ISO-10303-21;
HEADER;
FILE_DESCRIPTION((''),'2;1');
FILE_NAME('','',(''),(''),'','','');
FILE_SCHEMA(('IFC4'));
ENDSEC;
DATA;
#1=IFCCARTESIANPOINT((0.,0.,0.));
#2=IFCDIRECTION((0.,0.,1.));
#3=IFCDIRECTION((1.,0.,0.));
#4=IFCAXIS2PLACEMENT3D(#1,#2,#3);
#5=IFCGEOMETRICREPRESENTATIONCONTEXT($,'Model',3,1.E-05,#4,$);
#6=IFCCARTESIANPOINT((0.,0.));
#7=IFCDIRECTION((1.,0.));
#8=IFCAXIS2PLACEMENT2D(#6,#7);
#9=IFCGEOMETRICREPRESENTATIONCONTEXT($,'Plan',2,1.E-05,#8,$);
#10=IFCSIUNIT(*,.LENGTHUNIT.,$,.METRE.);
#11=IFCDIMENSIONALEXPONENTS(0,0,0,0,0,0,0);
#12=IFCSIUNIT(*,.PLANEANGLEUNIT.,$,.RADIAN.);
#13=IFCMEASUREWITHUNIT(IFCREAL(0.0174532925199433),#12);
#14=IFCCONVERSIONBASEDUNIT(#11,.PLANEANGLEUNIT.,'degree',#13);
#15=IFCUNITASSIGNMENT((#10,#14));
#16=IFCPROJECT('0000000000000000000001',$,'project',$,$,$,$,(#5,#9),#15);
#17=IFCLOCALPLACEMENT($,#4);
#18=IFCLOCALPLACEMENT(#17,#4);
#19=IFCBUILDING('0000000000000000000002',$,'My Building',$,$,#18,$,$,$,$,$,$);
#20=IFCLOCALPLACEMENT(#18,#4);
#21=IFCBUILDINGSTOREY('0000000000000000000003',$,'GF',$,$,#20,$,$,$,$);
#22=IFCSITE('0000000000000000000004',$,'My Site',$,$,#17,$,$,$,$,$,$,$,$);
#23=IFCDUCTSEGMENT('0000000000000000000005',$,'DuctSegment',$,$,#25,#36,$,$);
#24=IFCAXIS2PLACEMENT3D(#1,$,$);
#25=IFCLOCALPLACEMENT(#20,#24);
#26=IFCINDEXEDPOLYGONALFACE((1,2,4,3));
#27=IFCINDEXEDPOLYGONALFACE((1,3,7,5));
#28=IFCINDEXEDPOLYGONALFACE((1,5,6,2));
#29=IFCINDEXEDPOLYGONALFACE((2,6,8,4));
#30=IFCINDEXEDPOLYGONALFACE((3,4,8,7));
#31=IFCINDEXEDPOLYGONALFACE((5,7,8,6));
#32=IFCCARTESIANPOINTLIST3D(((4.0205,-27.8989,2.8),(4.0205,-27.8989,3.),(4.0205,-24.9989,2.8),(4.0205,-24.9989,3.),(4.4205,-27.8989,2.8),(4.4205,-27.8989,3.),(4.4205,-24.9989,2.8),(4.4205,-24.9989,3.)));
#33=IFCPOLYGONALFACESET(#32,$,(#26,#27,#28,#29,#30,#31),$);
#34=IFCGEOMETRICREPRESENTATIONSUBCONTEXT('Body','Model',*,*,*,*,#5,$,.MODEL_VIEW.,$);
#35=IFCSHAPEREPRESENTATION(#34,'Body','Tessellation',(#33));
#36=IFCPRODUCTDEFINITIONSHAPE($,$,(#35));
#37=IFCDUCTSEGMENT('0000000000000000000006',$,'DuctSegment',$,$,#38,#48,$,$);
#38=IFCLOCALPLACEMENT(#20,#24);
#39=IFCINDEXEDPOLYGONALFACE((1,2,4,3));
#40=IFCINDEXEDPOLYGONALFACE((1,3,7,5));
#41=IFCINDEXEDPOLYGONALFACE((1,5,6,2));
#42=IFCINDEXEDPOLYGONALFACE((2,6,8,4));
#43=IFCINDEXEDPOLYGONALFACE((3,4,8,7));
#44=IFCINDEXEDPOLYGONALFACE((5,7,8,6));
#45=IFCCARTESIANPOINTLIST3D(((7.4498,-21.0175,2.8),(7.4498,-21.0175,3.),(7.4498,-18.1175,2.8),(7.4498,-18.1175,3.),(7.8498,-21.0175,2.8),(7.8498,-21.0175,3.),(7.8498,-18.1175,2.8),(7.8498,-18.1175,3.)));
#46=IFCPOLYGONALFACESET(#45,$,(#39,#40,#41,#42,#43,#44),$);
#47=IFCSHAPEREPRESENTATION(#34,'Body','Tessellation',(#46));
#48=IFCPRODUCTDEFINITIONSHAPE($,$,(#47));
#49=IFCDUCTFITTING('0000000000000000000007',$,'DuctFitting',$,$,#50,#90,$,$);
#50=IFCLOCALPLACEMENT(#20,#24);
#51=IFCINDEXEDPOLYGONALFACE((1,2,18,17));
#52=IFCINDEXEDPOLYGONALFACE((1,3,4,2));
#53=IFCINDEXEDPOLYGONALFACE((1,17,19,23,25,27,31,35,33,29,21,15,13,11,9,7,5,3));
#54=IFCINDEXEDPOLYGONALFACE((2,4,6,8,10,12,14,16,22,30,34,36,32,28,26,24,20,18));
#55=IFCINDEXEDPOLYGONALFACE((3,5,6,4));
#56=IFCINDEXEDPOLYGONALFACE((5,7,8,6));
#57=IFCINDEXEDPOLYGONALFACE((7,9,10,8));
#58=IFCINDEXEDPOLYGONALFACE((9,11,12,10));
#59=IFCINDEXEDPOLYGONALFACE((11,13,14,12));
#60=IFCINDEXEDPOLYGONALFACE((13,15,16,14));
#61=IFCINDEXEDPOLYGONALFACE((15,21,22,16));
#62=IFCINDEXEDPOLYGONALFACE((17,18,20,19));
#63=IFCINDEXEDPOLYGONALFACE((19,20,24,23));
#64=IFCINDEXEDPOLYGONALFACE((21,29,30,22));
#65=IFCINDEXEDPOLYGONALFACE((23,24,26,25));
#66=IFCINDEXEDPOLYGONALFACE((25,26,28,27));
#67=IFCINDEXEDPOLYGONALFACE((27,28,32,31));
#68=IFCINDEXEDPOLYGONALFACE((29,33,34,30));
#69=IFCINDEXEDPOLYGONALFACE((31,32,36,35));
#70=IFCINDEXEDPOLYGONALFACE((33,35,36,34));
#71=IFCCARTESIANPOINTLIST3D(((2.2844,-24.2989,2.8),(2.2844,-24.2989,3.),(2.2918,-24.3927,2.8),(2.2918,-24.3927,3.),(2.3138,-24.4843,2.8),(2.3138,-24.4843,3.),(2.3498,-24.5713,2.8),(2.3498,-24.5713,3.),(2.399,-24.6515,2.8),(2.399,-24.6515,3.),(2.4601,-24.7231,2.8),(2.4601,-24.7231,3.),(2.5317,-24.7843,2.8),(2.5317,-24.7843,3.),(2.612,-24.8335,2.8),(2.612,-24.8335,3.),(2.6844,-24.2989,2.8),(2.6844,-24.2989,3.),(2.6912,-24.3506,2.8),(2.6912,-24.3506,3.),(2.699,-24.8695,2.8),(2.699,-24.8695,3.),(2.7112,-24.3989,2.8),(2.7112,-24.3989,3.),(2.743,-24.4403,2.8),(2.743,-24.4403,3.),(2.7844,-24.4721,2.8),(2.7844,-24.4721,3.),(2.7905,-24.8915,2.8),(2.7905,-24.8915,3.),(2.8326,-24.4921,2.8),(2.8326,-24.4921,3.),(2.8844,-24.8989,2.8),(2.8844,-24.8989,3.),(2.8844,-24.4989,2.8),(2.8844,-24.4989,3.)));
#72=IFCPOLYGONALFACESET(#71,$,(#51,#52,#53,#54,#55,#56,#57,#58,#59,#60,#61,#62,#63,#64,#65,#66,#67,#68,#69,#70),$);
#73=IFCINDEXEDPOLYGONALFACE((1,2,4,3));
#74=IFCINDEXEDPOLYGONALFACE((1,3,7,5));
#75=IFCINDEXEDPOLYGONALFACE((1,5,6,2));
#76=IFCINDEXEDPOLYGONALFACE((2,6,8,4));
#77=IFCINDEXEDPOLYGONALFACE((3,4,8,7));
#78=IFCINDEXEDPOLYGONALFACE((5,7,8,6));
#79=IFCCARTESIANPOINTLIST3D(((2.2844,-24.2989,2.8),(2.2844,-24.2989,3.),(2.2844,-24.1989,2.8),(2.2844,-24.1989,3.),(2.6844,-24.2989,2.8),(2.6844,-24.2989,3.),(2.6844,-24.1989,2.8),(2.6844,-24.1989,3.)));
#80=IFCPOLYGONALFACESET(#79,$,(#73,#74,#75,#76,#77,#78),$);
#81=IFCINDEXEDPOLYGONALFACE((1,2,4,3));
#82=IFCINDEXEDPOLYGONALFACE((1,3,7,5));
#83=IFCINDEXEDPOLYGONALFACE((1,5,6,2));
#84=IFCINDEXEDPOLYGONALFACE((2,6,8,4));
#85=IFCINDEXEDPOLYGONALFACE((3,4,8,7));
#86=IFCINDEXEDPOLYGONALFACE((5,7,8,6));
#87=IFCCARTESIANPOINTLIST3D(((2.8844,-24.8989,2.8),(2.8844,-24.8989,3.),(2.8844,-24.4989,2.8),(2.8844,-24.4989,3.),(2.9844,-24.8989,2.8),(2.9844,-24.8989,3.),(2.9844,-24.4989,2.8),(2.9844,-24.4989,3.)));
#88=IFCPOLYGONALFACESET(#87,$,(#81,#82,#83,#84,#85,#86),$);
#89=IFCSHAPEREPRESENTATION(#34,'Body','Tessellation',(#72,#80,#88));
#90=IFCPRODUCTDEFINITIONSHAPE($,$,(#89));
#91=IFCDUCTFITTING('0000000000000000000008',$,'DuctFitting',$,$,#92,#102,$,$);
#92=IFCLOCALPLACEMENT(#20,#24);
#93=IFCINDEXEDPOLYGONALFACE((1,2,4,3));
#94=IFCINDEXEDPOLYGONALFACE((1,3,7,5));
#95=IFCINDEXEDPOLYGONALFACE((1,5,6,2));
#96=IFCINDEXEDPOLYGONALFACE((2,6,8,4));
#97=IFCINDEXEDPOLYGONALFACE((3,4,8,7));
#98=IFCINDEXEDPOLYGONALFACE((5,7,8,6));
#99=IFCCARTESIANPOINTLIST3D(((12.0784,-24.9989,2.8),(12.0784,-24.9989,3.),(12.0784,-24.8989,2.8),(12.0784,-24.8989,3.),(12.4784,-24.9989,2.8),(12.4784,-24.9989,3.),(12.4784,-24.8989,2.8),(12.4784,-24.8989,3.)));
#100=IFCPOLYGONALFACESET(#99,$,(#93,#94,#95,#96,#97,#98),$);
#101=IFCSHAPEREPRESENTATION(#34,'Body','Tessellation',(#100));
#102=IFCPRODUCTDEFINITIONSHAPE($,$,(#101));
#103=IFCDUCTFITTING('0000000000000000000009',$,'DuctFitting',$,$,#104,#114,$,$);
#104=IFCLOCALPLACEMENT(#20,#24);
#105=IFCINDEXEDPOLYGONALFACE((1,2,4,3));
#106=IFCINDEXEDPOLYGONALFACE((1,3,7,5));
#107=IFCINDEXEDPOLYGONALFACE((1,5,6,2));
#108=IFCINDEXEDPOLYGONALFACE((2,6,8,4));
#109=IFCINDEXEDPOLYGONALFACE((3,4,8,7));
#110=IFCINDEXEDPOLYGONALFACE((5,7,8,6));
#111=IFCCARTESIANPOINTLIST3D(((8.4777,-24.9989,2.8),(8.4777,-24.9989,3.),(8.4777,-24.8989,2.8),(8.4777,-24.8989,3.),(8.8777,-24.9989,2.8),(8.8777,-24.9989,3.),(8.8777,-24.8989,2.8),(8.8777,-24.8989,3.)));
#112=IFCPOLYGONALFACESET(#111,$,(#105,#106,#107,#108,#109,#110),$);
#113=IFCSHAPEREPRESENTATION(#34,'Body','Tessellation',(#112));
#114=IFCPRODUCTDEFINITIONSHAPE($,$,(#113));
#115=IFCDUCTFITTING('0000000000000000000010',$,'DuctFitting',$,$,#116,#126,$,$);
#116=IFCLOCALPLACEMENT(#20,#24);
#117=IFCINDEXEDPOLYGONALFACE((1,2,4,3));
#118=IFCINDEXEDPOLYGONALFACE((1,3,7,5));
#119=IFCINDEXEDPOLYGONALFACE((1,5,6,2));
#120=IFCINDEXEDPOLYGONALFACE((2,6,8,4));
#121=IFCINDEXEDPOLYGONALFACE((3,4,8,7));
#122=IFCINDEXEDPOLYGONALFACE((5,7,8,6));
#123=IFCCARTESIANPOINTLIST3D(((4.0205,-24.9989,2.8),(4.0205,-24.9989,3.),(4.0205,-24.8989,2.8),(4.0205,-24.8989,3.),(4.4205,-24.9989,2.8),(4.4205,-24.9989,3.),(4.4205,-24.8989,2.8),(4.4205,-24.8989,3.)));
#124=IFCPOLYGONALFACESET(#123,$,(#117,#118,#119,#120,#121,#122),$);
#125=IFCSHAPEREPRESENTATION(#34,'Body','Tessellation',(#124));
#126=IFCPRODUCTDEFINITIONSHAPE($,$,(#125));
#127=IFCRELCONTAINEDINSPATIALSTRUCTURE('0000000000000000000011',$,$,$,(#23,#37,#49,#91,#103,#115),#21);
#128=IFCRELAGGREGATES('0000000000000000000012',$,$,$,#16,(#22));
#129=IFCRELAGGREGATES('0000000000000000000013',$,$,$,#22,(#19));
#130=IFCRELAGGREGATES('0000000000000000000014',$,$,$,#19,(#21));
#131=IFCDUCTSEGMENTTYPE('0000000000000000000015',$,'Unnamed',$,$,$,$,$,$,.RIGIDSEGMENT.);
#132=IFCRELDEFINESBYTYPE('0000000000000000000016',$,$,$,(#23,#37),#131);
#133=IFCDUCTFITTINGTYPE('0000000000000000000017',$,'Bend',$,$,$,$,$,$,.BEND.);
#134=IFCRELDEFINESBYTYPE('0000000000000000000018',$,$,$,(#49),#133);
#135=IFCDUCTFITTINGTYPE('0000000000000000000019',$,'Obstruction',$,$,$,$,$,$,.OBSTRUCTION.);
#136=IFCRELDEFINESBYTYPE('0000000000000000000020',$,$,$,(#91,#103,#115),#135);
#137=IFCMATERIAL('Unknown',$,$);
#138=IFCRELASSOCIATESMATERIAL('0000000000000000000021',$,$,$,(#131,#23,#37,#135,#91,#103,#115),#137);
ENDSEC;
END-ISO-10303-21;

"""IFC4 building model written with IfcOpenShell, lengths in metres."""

from ifc_helpers import new_model, entity, si_unit, converted_unit, frame, origin_with_axes, origin_2d_with_axis, place, context, subcontext, project, spatial, line, arc, indexed_curve, rectangle, outline, extrude, source, transform, mapped, material, material_profile, profile_set, profile_usage, type_object, type_shapes, element, save


model = new_model("IFC4")

# Units and contexts
model_context = context("Model", 3, precision=1e-05, world=origin_with_axes())
plan_context = context("Plan", 2, precision=1e-05, world=origin_2d_with_axis())
body_context_1 = subcontext(model_context, "Body", "Model", "MODEL_VIEW")
ifc_project = project(units=[si_unit("LENGTHUNIT", "METRE"), converted_unit("PLANEANGLEUNIT", "degree", entity("IfcReal", 0.0174532925199433), si_unit("PLANEANGLEUNIT", "RADIAN"), dimensions=[0, 0, 0, 0, 0, 0, 0])], contexts=[model_context, plan_context])

# Site, building, storey
site_placement = place(None, origin_with_axes())
site = spatial("IfcSite", under=ifc_project, at=site_placement, Name="My Site")
building_placement = place(site_placement, origin_with_axes())
building = spatial("IfcBuilding", under=site, at=building_placement, Name="My Building")
storey_placement = place(building_placement, origin_with_axes())
storey = spatial("IfcBuildingStorey", under=building, at=storey_placement, Name="GF")

# Shared definitions
ifc_material = material(Name="Unknown")

# Duct segments
ifc_material_profile_1 = material_profile(ifc_material, rectangle(XDim=0.4, YDim=0.2))
ifc_profile_set_1 = profile_set([ifc_material_profile_1])
duct_segment_type = type_object("IfcDuctSegmentType", Name="Unnamed", PredefinedType="RIGIDSEGMENT", material=ifc_profile_set_1)
ifc_profile_usage_1 = profile_usage(ifc_profile_set_1, cardinal=5)
duct_segment_1_placement = place(storey_placement, frame((4.2205, -24.9989, 2.9), z_axis=(0.0, -1.0, 0.0), x_axis=(1.0, 0.0, 0.0)))
element("IfcDuctSegment", 1, at=duct_segment_1_placement, inside=storey, type_object=duct_segment_type, material=ifc_profile_usage_1, Name="DuctSegment", context=body_context_1, shape_type="SweptSolid", body=[
    extrude(rectangle(XDim=0.4, YDim=0.2), origin_with_axes(), (0.0, 0.0, 1.0), 2.9),
])
ifc_profile_usage_2 = profile_usage(ifc_profile_set_1, cardinal=5)
duct_segment_2_placement = place(storey_placement, frame((7.6498, -18.1175, 2.9), z_axis=(0.0, -1.0, 0.0), x_axis=(1.0, 0.0, 0.0)))
element("IfcDuctSegment", 2, at=duct_segment_2_placement, inside=storey, type_object=duct_segment_type, material=ifc_profile_usage_2, Name="DuctSegment", context=body_context_1, shape_type="SweptSolid", body=[
    extrude(rectangle(XDim=0.4, YDim=0.2), origin_with_axes(), (0.0, 0.0, 1.0), 2.9),
])

# Duct fittings
duct_fitting_type_1 = type_object("IfcDuctFittingType", Name="Bend", PredefinedType="BEND")
shared_shape_1 = source(origin_with_axes(), body_context_1, "Body", "SweptSolid", [
    extrude(outline(indexed_curve([(-0.2, 0.0), (-0.2586, -0.1414), (-0.4, -0.2), (-0.4, -0.6), (0.0243, -0.4243), (0.2, 0.0)], segments=[arc(1, 2, 3), line(3, 4), arc(4, 5, 6), line(6, 1)])), frame((0.0, -0.1, -0.1), z_axis=(0.0, -1.0, 0.0), x_axis=(1.0, 0.0, 0.0)), (0.0, 0.0, -1.0), 0.2),
    extrude(rectangle(XDim=0.4, YDim=0.2), origin_with_axes(), (0.0, 0.0, -1.0), 0.1),
    extrude(rectangle(XDim=0.4, YDim=0.2), frame((-0.4, 0.0, -0.5), z_axis=(-1.0, 0.0, 0.0), x_axis=(0.0, 0.0, -1.0)), (0.0, 0.0, 1.0), 0.1),
])
type_shapes(duct_fitting_type_1, [shared_shape_1])
duct_fitting_1_placement = place(storey_placement, frame((2.4844, -24.1989, 2.9), z_axis=(0.0, 1.0, 0.0), x_axis=(-1.0, 0.0, 0.0)))
element("IfcDuctFitting", 3, at=duct_fitting_1_placement, inside=storey, type_object=duct_fitting_type_1, Name="DuctFitting", context=body_context_1, shape_type="MappedRepresentation", body=[
    mapped(shared_shape_1, transform((0.0, 0.0, 0.0), x_axis=(1.0, 0.0, 0.0), y_axis=(0.0, 1.0, 0.0), z_axis=(0.0, 0.0, 1.0), scale=1.0)),
])
ifc_material_profile_2 = material_profile(ifc_material, rectangle(XDim=0.4, YDim=0.2))
ifc_profile_set_2 = profile_set([ifc_material_profile_2])
ifc_profile_usage_3 = profile_usage(ifc_profile_set_2, cardinal=5)
duct_fitting_type_2 = type_object("IfcDuctFittingType", Name="Obstruction", PredefinedType="OBSTRUCTION", material=ifc_profile_set_2)
duct_fitting_2_placement = place(storey_placement, frame((12.2784, -24.8989, 2.9), z_axis=(0.0, -1.0, 0.0), x_axis=(1.0, 0.0, 0.0)))
element("IfcDuctFitting", 4, at=duct_fitting_2_placement, inside=storey, type_object=duct_fitting_type_2, material=ifc_profile_usage_3, Name="DuctFitting", context=body_context_1, shape_type="SweptSolid", body=[
    extrude(rectangle(XDim=0.4, YDim=0.2), origin_with_axes(), (0.0, 0.0, 1.0), 0.1),
])
ifc_profile_usage_4 = profile_usage(ifc_profile_set_2, cardinal=5)
duct_fitting_3_placement = place(storey_placement, frame((8.6777, -24.8989, 2.9), z_axis=(0.0, -1.0, 0.0), x_axis=(1.0, 0.0, 0.0)))
element("IfcDuctFitting", 5, at=duct_fitting_3_placement, inside=storey, type_object=duct_fitting_type_2, material=ifc_profile_usage_4, Name="DuctFitting", context=body_context_1, shape_type="SweptSolid", body=[
    extrude(rectangle(XDim=0.4, YDim=0.2), origin_with_axes(), (0.0, 0.0, 1.0), 0.1),
])
ifc_profile_usage_5 = profile_usage(ifc_profile_set_2, cardinal=5)
duct_fitting_4_placement = place(storey_placement, frame((4.2205, -24.8989, 2.9), z_axis=(0.0, -1.0, 0.0), x_axis=(1.0, 0.0, 0.0)))
element("IfcDuctFitting", 6, at=duct_fitting_4_placement, inside=storey, type_object=duct_fitting_type_2, material=ifc_profile_usage_5, Name="DuctFitting", context=body_context_1, shape_type="SweptSolid", body=[
    extrude(rectangle(XDim=0.4, YDim=0.2), origin_with_axes(), (0.0, 0.0, 1.0), 0.1),
])

save(model, "model.ifc")
